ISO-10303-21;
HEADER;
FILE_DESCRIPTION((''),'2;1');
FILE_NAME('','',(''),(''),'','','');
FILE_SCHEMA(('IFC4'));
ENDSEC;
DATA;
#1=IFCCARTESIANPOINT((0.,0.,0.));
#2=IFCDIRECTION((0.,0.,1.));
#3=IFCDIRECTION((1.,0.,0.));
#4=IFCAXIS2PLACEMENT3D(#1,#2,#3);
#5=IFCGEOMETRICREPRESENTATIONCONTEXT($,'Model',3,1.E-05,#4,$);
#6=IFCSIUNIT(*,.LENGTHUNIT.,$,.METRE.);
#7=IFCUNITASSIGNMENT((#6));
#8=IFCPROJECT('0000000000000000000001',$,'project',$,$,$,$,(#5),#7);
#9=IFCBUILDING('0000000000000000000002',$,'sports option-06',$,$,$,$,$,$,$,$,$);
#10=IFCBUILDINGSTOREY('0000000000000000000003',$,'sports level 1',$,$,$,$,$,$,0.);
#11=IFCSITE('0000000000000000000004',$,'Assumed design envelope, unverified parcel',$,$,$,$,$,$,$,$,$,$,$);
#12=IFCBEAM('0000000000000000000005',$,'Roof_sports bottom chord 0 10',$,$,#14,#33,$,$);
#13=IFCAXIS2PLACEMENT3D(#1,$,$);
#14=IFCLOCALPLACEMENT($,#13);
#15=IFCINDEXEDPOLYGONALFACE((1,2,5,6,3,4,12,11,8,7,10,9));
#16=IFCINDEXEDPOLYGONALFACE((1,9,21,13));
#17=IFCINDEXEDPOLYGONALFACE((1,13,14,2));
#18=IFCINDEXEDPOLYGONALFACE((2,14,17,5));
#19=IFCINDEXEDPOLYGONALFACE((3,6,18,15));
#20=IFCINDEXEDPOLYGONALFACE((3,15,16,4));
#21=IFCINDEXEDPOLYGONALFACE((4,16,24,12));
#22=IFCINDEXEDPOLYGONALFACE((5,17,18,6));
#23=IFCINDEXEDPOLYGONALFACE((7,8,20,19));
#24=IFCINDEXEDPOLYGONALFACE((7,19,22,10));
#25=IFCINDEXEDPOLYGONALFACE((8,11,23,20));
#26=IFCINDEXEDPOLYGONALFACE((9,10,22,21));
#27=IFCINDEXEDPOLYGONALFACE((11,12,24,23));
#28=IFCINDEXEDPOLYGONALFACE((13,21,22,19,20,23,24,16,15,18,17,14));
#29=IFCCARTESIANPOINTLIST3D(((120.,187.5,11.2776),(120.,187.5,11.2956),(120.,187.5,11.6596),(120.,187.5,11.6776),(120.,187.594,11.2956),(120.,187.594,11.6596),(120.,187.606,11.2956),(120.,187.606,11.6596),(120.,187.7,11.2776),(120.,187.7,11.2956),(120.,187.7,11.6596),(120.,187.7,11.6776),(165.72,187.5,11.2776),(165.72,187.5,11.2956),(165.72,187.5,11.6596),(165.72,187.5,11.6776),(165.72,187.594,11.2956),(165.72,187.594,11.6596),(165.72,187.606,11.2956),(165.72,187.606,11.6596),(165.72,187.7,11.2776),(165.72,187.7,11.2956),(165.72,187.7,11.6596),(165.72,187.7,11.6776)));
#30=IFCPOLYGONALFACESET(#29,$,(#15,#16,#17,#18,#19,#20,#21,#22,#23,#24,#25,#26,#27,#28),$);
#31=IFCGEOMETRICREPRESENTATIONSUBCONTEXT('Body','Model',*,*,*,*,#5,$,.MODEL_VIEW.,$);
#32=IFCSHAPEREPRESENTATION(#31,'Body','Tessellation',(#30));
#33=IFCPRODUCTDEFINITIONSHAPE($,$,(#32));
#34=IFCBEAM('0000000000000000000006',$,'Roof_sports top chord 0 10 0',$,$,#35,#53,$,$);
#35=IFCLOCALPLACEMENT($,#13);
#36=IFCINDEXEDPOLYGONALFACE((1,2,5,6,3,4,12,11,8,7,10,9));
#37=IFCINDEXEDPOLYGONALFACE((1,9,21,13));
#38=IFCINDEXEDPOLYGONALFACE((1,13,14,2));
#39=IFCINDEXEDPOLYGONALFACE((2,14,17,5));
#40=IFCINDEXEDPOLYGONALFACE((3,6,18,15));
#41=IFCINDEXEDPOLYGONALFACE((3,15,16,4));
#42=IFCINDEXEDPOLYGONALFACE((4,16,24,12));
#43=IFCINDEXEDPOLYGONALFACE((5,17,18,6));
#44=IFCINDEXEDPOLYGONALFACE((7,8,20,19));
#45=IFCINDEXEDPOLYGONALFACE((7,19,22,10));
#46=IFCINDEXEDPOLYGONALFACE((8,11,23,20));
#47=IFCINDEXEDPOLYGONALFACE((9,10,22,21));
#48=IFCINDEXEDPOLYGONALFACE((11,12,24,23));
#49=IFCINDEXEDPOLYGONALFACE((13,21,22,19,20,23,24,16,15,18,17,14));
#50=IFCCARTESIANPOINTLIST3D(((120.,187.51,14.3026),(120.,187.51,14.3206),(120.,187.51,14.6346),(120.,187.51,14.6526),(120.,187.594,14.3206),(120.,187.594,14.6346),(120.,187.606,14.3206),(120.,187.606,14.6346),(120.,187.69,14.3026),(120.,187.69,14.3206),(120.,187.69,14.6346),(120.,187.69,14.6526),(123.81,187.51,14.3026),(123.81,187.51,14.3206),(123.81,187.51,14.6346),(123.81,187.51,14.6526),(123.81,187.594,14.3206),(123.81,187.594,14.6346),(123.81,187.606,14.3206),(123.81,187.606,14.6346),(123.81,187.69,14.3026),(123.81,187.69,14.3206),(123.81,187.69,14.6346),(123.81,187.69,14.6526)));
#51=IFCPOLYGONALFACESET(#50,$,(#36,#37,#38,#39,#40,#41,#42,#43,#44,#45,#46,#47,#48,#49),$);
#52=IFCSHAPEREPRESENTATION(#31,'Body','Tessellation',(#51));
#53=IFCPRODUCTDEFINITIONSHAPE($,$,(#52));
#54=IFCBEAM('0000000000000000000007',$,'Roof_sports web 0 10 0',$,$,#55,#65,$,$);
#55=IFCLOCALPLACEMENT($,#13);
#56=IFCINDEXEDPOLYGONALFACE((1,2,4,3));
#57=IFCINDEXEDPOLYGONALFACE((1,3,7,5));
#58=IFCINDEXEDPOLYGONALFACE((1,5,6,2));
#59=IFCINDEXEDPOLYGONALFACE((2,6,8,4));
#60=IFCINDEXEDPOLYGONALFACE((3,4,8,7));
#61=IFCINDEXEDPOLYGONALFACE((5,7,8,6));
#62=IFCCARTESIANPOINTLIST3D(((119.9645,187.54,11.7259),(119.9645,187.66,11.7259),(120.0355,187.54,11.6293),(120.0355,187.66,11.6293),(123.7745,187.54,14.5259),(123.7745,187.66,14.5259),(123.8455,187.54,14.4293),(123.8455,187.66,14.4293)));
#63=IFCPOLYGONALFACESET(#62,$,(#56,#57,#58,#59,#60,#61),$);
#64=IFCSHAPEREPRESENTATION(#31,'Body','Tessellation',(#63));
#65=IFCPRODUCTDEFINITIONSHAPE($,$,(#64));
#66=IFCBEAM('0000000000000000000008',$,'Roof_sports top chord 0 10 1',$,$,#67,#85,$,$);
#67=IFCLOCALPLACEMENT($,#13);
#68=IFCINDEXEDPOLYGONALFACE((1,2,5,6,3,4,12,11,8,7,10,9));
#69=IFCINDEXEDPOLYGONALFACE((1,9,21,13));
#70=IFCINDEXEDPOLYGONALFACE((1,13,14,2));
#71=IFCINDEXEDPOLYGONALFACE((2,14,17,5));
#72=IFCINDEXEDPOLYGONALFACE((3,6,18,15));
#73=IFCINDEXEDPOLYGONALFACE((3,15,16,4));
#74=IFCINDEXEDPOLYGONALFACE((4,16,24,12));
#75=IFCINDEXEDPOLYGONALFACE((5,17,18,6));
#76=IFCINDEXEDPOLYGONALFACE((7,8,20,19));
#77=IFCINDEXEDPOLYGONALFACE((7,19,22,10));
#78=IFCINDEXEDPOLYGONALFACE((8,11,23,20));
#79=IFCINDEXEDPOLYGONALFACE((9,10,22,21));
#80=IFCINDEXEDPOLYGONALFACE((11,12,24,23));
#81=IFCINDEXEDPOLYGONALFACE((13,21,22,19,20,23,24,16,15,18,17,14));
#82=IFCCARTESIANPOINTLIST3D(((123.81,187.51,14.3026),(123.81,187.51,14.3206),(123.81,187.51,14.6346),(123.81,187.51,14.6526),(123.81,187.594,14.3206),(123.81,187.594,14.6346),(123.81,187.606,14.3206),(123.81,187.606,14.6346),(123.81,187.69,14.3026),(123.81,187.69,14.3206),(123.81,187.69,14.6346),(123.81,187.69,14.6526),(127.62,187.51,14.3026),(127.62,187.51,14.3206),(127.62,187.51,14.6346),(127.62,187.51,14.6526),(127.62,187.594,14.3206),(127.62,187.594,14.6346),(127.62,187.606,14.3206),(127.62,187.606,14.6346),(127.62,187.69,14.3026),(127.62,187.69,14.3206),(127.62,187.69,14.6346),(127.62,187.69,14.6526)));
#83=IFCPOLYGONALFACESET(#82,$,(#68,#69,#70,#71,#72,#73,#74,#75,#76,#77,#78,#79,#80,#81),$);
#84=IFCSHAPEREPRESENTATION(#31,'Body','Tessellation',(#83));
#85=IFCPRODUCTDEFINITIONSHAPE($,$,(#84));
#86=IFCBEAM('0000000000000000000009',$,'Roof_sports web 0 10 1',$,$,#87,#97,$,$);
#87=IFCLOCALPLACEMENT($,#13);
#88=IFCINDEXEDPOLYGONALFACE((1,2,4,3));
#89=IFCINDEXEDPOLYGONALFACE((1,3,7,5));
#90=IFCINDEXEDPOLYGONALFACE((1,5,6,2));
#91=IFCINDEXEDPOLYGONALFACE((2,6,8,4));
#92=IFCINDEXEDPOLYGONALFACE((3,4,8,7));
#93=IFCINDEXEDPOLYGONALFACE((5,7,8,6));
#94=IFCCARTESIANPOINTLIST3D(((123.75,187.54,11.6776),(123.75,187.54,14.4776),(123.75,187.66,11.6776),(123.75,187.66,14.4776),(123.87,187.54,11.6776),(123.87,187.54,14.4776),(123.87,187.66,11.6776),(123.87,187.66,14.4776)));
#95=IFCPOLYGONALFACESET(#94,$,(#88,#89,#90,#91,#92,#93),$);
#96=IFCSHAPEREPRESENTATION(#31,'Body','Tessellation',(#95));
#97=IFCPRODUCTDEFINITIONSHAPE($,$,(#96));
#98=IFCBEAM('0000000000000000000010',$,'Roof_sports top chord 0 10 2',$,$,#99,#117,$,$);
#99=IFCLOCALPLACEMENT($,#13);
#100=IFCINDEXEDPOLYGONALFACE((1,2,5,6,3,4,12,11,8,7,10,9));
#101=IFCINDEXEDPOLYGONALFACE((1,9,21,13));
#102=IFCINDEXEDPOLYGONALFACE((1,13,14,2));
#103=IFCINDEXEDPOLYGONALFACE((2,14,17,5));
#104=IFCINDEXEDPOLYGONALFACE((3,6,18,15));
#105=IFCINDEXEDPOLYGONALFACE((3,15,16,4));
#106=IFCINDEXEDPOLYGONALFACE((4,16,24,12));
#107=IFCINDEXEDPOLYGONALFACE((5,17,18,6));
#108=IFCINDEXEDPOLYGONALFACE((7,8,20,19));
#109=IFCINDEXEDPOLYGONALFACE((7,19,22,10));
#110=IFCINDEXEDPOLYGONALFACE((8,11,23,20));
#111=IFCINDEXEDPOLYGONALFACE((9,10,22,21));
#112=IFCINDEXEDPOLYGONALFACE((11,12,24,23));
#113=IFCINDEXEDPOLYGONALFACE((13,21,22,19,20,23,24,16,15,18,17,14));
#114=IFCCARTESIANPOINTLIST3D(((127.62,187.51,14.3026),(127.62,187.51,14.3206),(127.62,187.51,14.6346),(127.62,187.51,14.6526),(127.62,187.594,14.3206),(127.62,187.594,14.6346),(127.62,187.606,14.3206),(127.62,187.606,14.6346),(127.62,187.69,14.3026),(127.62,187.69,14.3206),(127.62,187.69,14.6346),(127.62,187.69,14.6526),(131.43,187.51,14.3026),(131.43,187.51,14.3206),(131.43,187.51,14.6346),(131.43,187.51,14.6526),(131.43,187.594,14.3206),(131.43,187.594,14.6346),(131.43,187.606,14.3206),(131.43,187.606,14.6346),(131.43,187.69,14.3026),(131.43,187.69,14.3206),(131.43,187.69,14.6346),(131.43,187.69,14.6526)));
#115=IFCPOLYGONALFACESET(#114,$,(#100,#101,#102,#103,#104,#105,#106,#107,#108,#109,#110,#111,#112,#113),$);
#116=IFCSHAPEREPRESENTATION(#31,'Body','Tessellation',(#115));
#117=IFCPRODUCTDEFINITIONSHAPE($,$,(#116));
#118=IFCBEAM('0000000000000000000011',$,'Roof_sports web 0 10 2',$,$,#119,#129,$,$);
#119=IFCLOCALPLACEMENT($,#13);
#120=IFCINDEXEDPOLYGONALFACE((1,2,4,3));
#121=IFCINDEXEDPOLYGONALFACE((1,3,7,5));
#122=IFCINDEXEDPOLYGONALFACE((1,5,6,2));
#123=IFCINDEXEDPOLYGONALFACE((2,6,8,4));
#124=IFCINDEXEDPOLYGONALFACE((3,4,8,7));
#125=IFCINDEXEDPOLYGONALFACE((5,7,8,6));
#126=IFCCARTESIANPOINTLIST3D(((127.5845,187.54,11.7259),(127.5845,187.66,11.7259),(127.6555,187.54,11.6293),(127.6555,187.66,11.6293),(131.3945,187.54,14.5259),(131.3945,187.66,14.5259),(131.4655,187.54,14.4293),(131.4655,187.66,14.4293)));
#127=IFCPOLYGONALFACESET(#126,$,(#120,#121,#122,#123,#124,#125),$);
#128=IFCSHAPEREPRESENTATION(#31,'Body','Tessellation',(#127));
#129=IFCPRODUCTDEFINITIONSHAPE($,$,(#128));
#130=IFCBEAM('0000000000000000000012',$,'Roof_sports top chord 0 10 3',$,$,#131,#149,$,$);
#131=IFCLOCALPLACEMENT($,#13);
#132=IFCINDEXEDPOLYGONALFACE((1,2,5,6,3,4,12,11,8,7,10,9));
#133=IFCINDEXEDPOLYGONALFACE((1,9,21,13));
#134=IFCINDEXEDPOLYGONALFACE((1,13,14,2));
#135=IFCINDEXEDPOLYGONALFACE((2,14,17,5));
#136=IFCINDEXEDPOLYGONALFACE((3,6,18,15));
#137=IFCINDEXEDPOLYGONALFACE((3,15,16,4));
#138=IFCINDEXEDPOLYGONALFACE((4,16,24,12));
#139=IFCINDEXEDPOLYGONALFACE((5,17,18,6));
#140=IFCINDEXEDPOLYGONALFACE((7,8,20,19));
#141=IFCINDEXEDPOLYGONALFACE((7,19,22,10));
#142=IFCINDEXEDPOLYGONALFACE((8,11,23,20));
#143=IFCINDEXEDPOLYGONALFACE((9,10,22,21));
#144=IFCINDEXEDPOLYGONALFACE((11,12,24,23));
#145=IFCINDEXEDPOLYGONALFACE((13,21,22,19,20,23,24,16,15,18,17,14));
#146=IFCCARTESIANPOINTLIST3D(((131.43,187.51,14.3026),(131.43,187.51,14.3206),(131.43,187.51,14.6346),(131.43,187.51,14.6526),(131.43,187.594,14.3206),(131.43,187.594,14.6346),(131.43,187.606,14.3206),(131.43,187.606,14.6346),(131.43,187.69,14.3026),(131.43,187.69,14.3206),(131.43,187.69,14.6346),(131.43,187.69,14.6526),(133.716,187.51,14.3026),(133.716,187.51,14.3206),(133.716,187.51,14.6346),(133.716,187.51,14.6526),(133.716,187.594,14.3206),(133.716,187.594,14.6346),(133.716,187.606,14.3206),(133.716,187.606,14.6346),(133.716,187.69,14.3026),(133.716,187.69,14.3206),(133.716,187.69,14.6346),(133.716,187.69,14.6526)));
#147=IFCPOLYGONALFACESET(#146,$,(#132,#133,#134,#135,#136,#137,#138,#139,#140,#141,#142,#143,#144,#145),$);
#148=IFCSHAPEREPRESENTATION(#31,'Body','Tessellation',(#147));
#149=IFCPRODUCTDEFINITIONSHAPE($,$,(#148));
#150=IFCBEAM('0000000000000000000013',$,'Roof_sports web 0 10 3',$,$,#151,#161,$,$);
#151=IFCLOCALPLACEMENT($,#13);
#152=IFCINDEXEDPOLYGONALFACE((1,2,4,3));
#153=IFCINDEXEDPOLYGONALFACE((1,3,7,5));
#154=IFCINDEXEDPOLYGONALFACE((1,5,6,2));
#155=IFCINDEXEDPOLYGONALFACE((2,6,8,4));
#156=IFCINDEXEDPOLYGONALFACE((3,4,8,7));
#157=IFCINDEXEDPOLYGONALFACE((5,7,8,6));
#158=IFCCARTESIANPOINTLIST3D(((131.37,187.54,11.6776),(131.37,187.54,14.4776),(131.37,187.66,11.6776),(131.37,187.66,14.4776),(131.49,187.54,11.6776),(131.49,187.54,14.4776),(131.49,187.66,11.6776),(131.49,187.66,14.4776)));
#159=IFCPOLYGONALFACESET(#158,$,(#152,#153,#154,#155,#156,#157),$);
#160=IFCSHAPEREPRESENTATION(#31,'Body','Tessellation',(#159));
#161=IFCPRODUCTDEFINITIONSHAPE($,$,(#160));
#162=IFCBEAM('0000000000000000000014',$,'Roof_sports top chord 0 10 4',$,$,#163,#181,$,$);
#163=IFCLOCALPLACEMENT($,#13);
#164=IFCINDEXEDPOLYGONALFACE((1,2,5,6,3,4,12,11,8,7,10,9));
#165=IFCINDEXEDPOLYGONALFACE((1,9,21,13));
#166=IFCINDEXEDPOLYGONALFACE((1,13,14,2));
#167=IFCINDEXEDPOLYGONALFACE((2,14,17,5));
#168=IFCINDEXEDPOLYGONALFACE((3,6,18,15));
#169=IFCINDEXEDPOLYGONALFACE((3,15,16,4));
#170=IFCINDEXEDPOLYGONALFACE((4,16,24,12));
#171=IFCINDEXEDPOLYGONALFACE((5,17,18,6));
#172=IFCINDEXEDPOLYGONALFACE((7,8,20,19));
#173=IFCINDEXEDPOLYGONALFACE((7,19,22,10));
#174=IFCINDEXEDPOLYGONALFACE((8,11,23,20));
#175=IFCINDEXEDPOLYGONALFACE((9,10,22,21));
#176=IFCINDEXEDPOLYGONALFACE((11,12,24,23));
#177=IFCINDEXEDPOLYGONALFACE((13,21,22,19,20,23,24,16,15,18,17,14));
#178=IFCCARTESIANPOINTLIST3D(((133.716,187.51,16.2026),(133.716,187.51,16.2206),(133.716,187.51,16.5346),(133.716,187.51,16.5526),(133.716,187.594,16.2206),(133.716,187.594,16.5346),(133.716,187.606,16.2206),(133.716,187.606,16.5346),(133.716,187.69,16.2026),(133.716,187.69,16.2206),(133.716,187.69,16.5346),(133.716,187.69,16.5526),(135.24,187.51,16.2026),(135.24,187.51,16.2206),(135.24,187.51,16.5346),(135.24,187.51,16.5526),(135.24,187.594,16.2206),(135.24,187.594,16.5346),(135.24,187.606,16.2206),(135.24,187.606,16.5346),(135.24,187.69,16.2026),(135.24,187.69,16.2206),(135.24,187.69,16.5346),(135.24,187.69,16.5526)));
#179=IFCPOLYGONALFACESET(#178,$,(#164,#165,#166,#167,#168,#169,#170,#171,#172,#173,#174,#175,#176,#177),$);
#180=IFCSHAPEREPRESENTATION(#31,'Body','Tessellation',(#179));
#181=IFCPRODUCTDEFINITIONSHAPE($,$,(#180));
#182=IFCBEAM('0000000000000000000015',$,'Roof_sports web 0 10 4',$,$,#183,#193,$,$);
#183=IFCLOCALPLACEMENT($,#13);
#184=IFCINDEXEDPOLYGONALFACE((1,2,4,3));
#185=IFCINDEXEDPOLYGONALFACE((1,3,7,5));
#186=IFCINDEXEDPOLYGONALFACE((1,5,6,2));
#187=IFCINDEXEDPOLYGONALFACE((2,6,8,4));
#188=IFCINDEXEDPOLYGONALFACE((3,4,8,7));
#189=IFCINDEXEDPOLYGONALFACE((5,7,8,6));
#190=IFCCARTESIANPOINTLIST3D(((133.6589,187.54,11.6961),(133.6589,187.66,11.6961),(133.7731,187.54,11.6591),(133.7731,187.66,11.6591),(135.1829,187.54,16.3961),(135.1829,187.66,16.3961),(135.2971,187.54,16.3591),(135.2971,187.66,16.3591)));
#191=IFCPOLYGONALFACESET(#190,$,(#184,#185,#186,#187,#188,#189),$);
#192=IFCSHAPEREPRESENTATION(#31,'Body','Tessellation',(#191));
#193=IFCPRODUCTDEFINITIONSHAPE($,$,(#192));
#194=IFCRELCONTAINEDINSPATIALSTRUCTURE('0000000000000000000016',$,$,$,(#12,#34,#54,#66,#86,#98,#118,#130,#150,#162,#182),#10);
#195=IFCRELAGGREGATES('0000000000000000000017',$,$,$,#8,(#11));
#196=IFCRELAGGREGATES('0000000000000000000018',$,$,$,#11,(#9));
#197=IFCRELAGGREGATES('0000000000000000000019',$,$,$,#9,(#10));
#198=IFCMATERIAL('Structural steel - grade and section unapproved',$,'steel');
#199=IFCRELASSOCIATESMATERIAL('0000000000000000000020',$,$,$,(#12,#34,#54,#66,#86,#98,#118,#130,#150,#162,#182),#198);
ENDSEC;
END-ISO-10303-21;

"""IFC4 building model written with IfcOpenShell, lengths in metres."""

from ifc_helpers import new_model, si_unit, frame, origin_with_axes, place, context, subcontext, project, spatial, rectangle, i_section, extrude, material, element, save


model = new_model("IFC4")

# Units and contexts
model_context = context("Model", 3, precision=1e-05, world=origin_with_axes())
body_context = subcontext(model_context, "Body", "Model", "MODEL_VIEW")
ifc_project = project(units=[si_unit("LENGTHUNIT", "METRE")], contexts=[model_context])

# Site, building, storey
site = spatial("IfcSite", under=ifc_project, Name="Assumed design envelope, unverified parcel")
building = spatial("IfcBuilding", under=site, Name="sports option-06")
storey = spatial("IfcBuildingStorey", under=building, Name="sports level 1", Elevation=0.0)

# Shared definitions
ifc_material_1 = material(Name="Structural steel - grade and section unapproved", Category="steel")

# Beams
beam_1_placement = place(None, frame((120.0, 187.6, 11.4776), z_axis=(1.0, 0.0, 0.0), x_axis=(0.0, 1.0, 0.0)))
element("IfcBeam", 1, at=beam_1_placement, inside=storey, material=ifc_material_1, Name="Roof_sports bottom chord 0 10", context=body_context, shape_type="SweptSolid", body=[
    extrude(i_section(OverallWidth=0.2, OverallDepth=0.4, WebThickness=0.012, FlangeThickness=0.018, FilletRadius=0.0), origin_with_axes(), (0.0, 0.0, 1.0), 45.72),
])
beam_2_placement = place(None, frame((120.0, 187.6, 14.4776), z_axis=(1.0, 0.0, 0.0), x_axis=(0.0, 1.0, 0.0)))
element("IfcBeam", 2, at=beam_2_placement, inside=storey, material=ifc_material_1, Name="Roof_sports top chord 0 10 0", context=body_context, shape_type="SweptSolid", body=[
    extrude(i_section(OverallWidth=0.18, OverallDepth=0.35, WebThickness=0.012, FlangeThickness=0.018, FilletRadius=0.0), origin_with_axes(), (0.0, 0.0, 1.0), 3.81),
])
beam_3_placement = place(None, frame((120.0, 187.6, 11.6776), z_axis=(0.805799, 0.0, 0.592189), x_axis=(0.0, 1.0, 0.0)))
element("IfcBeam", 3, at=beam_3_placement, inside=storey, material=ifc_material_1, Name="Roof_sports web 0 10 0", context=body_context, shape_type="SweptSolid", body=[
    extrude(rectangle(XDim=0.12, YDim=0.12), origin_with_axes(), (0.0, 0.0, 1.0), 4.7282),
])
beam_4_placement = place(None, frame((123.81, 187.6, 14.4776), z_axis=(1.0, 0.0, 0.0), x_axis=(0.0, 1.0, 0.0)))
element("IfcBeam", 4, at=beam_4_placement, inside=storey, material=ifc_material_1, Name="Roof_sports top chord 0 10 1", context=body_context, shape_type="SweptSolid", body=[
    extrude(i_section(OverallWidth=0.18, OverallDepth=0.35, WebThickness=0.012, FlangeThickness=0.018, FilletRadius=0.0), origin_with_axes(), (0.0, 0.0, 1.0), 3.81),
])
beam_5_placement = place(None, frame((123.81, 187.6, 11.6776), z_axis=(0.0, 0.0, 1.0), x_axis=(-1.0, 0.0, 0.0)))
element("IfcBeam", 5, at=beam_5_placement, inside=storey, material=ifc_material_1, Name="Roof_sports web 0 10 1", context=body_context, shape_type="SweptSolid", body=[
    extrude(rectangle(XDim=0.12, YDim=0.12), origin_with_axes(), (0.0, 0.0, 1.0), 2.8),
])
beam_6_placement = place(None, frame((127.62, 187.6, 14.4776), z_axis=(1.0, 0.0, 0.0), x_axis=(0.0, 1.0, 0.0)))
element("IfcBeam", 6, at=beam_6_placement, inside=storey, material=ifc_material_1, Name="Roof_sports top chord 0 10 2", context=body_context, shape_type="SweptSolid", body=[
    extrude(i_section(OverallWidth=0.18, OverallDepth=0.35, WebThickness=0.012, FlangeThickness=0.018, FilletRadius=0.0), origin_with_axes(), (0.0, 0.0, 1.0), 3.81),
])
beam_7_placement = place(None, frame((127.62, 187.6, 11.6776), z_axis=(0.805799, 0.0, 0.59219), x_axis=(0.0, 1.0, 0.0)))
element("IfcBeam", 7, at=beam_7_placement, inside=storey, material=ifc_material_1, Name="Roof_sports web 0 10 2", context=body_context, shape_type="SweptSolid", body=[
    extrude(rectangle(XDim=0.12, YDim=0.12), origin_with_axes(), (0.0, 0.0, 1.0), 4.7282),
])
beam_8_placement = place(None, frame((131.43, 187.6, 14.4776), z_axis=(1.0, 0.0, 0.0), x_axis=(0.0, 1.0, 0.0)))
element("IfcBeam", 8, at=beam_8_placement, inside=storey, material=ifc_material_1, Name="Roof_sports top chord 0 10 3", context=body_context, shape_type="SweptSolid", body=[
    extrude(i_section(OverallWidth=0.18, OverallDepth=0.35, WebThickness=0.012, FlangeThickness=0.018, FilletRadius=0.0), origin_with_axes(), (0.0, 0.0, 1.0), 2.286),
])
beam_9_placement = place(None, frame((131.43, 187.6, 11.6776), z_axis=(0.0, 0.0, 1.0), x_axis=(-1.0, 0.0, 0.0)))
element("IfcBeam", 9, at=beam_9_placement, inside=storey, material=ifc_material_1, Name="Roof_sports web 0 10 3", context=body_context, shape_type="SweptSolid", body=[
    extrude(rectangle(XDim=0.12, YDim=0.12), origin_with_axes(), (0.0, 0.0, 1.0), 2.8),
])
beam_10_placement = place(None, frame((133.716, 187.6, 16.3776), z_axis=(1.0, 0.0, 0.0), x_axis=(0.0, 1.0, 0.0)))
element("IfcBeam", 10, at=beam_10_placement, inside=storey, material=ifc_material_1, Name="Roof_sports top chord 0 10 4", context=body_context, shape_type="SweptSolid", body=[
    extrude(i_section(OverallWidth=0.18, OverallDepth=0.35, WebThickness=0.012, FlangeThickness=0.018, FilletRadius=0.0), origin_with_axes(), (0.0, 0.0, 1.0), 1.524),
])
beam_11_placement = place(None, frame((133.716, 187.6, 11.6776), z_axis=(0.308446, 0.0, 0.951242), x_axis=(0.0, 1.0, 0.0)))
element("IfcBeam", 11, at=beam_11_placement, inside=storey, material=ifc_material_1, Name="Roof_sports web 0 10 4", context=body_context, shape_type="SweptSolid", body=[
    extrude(rectangle(XDim=0.12, YDim=0.12), origin_with_axes(), (0.0, 0.0, 1.0), 4.9409),
])

save(model, "model.ifc")
